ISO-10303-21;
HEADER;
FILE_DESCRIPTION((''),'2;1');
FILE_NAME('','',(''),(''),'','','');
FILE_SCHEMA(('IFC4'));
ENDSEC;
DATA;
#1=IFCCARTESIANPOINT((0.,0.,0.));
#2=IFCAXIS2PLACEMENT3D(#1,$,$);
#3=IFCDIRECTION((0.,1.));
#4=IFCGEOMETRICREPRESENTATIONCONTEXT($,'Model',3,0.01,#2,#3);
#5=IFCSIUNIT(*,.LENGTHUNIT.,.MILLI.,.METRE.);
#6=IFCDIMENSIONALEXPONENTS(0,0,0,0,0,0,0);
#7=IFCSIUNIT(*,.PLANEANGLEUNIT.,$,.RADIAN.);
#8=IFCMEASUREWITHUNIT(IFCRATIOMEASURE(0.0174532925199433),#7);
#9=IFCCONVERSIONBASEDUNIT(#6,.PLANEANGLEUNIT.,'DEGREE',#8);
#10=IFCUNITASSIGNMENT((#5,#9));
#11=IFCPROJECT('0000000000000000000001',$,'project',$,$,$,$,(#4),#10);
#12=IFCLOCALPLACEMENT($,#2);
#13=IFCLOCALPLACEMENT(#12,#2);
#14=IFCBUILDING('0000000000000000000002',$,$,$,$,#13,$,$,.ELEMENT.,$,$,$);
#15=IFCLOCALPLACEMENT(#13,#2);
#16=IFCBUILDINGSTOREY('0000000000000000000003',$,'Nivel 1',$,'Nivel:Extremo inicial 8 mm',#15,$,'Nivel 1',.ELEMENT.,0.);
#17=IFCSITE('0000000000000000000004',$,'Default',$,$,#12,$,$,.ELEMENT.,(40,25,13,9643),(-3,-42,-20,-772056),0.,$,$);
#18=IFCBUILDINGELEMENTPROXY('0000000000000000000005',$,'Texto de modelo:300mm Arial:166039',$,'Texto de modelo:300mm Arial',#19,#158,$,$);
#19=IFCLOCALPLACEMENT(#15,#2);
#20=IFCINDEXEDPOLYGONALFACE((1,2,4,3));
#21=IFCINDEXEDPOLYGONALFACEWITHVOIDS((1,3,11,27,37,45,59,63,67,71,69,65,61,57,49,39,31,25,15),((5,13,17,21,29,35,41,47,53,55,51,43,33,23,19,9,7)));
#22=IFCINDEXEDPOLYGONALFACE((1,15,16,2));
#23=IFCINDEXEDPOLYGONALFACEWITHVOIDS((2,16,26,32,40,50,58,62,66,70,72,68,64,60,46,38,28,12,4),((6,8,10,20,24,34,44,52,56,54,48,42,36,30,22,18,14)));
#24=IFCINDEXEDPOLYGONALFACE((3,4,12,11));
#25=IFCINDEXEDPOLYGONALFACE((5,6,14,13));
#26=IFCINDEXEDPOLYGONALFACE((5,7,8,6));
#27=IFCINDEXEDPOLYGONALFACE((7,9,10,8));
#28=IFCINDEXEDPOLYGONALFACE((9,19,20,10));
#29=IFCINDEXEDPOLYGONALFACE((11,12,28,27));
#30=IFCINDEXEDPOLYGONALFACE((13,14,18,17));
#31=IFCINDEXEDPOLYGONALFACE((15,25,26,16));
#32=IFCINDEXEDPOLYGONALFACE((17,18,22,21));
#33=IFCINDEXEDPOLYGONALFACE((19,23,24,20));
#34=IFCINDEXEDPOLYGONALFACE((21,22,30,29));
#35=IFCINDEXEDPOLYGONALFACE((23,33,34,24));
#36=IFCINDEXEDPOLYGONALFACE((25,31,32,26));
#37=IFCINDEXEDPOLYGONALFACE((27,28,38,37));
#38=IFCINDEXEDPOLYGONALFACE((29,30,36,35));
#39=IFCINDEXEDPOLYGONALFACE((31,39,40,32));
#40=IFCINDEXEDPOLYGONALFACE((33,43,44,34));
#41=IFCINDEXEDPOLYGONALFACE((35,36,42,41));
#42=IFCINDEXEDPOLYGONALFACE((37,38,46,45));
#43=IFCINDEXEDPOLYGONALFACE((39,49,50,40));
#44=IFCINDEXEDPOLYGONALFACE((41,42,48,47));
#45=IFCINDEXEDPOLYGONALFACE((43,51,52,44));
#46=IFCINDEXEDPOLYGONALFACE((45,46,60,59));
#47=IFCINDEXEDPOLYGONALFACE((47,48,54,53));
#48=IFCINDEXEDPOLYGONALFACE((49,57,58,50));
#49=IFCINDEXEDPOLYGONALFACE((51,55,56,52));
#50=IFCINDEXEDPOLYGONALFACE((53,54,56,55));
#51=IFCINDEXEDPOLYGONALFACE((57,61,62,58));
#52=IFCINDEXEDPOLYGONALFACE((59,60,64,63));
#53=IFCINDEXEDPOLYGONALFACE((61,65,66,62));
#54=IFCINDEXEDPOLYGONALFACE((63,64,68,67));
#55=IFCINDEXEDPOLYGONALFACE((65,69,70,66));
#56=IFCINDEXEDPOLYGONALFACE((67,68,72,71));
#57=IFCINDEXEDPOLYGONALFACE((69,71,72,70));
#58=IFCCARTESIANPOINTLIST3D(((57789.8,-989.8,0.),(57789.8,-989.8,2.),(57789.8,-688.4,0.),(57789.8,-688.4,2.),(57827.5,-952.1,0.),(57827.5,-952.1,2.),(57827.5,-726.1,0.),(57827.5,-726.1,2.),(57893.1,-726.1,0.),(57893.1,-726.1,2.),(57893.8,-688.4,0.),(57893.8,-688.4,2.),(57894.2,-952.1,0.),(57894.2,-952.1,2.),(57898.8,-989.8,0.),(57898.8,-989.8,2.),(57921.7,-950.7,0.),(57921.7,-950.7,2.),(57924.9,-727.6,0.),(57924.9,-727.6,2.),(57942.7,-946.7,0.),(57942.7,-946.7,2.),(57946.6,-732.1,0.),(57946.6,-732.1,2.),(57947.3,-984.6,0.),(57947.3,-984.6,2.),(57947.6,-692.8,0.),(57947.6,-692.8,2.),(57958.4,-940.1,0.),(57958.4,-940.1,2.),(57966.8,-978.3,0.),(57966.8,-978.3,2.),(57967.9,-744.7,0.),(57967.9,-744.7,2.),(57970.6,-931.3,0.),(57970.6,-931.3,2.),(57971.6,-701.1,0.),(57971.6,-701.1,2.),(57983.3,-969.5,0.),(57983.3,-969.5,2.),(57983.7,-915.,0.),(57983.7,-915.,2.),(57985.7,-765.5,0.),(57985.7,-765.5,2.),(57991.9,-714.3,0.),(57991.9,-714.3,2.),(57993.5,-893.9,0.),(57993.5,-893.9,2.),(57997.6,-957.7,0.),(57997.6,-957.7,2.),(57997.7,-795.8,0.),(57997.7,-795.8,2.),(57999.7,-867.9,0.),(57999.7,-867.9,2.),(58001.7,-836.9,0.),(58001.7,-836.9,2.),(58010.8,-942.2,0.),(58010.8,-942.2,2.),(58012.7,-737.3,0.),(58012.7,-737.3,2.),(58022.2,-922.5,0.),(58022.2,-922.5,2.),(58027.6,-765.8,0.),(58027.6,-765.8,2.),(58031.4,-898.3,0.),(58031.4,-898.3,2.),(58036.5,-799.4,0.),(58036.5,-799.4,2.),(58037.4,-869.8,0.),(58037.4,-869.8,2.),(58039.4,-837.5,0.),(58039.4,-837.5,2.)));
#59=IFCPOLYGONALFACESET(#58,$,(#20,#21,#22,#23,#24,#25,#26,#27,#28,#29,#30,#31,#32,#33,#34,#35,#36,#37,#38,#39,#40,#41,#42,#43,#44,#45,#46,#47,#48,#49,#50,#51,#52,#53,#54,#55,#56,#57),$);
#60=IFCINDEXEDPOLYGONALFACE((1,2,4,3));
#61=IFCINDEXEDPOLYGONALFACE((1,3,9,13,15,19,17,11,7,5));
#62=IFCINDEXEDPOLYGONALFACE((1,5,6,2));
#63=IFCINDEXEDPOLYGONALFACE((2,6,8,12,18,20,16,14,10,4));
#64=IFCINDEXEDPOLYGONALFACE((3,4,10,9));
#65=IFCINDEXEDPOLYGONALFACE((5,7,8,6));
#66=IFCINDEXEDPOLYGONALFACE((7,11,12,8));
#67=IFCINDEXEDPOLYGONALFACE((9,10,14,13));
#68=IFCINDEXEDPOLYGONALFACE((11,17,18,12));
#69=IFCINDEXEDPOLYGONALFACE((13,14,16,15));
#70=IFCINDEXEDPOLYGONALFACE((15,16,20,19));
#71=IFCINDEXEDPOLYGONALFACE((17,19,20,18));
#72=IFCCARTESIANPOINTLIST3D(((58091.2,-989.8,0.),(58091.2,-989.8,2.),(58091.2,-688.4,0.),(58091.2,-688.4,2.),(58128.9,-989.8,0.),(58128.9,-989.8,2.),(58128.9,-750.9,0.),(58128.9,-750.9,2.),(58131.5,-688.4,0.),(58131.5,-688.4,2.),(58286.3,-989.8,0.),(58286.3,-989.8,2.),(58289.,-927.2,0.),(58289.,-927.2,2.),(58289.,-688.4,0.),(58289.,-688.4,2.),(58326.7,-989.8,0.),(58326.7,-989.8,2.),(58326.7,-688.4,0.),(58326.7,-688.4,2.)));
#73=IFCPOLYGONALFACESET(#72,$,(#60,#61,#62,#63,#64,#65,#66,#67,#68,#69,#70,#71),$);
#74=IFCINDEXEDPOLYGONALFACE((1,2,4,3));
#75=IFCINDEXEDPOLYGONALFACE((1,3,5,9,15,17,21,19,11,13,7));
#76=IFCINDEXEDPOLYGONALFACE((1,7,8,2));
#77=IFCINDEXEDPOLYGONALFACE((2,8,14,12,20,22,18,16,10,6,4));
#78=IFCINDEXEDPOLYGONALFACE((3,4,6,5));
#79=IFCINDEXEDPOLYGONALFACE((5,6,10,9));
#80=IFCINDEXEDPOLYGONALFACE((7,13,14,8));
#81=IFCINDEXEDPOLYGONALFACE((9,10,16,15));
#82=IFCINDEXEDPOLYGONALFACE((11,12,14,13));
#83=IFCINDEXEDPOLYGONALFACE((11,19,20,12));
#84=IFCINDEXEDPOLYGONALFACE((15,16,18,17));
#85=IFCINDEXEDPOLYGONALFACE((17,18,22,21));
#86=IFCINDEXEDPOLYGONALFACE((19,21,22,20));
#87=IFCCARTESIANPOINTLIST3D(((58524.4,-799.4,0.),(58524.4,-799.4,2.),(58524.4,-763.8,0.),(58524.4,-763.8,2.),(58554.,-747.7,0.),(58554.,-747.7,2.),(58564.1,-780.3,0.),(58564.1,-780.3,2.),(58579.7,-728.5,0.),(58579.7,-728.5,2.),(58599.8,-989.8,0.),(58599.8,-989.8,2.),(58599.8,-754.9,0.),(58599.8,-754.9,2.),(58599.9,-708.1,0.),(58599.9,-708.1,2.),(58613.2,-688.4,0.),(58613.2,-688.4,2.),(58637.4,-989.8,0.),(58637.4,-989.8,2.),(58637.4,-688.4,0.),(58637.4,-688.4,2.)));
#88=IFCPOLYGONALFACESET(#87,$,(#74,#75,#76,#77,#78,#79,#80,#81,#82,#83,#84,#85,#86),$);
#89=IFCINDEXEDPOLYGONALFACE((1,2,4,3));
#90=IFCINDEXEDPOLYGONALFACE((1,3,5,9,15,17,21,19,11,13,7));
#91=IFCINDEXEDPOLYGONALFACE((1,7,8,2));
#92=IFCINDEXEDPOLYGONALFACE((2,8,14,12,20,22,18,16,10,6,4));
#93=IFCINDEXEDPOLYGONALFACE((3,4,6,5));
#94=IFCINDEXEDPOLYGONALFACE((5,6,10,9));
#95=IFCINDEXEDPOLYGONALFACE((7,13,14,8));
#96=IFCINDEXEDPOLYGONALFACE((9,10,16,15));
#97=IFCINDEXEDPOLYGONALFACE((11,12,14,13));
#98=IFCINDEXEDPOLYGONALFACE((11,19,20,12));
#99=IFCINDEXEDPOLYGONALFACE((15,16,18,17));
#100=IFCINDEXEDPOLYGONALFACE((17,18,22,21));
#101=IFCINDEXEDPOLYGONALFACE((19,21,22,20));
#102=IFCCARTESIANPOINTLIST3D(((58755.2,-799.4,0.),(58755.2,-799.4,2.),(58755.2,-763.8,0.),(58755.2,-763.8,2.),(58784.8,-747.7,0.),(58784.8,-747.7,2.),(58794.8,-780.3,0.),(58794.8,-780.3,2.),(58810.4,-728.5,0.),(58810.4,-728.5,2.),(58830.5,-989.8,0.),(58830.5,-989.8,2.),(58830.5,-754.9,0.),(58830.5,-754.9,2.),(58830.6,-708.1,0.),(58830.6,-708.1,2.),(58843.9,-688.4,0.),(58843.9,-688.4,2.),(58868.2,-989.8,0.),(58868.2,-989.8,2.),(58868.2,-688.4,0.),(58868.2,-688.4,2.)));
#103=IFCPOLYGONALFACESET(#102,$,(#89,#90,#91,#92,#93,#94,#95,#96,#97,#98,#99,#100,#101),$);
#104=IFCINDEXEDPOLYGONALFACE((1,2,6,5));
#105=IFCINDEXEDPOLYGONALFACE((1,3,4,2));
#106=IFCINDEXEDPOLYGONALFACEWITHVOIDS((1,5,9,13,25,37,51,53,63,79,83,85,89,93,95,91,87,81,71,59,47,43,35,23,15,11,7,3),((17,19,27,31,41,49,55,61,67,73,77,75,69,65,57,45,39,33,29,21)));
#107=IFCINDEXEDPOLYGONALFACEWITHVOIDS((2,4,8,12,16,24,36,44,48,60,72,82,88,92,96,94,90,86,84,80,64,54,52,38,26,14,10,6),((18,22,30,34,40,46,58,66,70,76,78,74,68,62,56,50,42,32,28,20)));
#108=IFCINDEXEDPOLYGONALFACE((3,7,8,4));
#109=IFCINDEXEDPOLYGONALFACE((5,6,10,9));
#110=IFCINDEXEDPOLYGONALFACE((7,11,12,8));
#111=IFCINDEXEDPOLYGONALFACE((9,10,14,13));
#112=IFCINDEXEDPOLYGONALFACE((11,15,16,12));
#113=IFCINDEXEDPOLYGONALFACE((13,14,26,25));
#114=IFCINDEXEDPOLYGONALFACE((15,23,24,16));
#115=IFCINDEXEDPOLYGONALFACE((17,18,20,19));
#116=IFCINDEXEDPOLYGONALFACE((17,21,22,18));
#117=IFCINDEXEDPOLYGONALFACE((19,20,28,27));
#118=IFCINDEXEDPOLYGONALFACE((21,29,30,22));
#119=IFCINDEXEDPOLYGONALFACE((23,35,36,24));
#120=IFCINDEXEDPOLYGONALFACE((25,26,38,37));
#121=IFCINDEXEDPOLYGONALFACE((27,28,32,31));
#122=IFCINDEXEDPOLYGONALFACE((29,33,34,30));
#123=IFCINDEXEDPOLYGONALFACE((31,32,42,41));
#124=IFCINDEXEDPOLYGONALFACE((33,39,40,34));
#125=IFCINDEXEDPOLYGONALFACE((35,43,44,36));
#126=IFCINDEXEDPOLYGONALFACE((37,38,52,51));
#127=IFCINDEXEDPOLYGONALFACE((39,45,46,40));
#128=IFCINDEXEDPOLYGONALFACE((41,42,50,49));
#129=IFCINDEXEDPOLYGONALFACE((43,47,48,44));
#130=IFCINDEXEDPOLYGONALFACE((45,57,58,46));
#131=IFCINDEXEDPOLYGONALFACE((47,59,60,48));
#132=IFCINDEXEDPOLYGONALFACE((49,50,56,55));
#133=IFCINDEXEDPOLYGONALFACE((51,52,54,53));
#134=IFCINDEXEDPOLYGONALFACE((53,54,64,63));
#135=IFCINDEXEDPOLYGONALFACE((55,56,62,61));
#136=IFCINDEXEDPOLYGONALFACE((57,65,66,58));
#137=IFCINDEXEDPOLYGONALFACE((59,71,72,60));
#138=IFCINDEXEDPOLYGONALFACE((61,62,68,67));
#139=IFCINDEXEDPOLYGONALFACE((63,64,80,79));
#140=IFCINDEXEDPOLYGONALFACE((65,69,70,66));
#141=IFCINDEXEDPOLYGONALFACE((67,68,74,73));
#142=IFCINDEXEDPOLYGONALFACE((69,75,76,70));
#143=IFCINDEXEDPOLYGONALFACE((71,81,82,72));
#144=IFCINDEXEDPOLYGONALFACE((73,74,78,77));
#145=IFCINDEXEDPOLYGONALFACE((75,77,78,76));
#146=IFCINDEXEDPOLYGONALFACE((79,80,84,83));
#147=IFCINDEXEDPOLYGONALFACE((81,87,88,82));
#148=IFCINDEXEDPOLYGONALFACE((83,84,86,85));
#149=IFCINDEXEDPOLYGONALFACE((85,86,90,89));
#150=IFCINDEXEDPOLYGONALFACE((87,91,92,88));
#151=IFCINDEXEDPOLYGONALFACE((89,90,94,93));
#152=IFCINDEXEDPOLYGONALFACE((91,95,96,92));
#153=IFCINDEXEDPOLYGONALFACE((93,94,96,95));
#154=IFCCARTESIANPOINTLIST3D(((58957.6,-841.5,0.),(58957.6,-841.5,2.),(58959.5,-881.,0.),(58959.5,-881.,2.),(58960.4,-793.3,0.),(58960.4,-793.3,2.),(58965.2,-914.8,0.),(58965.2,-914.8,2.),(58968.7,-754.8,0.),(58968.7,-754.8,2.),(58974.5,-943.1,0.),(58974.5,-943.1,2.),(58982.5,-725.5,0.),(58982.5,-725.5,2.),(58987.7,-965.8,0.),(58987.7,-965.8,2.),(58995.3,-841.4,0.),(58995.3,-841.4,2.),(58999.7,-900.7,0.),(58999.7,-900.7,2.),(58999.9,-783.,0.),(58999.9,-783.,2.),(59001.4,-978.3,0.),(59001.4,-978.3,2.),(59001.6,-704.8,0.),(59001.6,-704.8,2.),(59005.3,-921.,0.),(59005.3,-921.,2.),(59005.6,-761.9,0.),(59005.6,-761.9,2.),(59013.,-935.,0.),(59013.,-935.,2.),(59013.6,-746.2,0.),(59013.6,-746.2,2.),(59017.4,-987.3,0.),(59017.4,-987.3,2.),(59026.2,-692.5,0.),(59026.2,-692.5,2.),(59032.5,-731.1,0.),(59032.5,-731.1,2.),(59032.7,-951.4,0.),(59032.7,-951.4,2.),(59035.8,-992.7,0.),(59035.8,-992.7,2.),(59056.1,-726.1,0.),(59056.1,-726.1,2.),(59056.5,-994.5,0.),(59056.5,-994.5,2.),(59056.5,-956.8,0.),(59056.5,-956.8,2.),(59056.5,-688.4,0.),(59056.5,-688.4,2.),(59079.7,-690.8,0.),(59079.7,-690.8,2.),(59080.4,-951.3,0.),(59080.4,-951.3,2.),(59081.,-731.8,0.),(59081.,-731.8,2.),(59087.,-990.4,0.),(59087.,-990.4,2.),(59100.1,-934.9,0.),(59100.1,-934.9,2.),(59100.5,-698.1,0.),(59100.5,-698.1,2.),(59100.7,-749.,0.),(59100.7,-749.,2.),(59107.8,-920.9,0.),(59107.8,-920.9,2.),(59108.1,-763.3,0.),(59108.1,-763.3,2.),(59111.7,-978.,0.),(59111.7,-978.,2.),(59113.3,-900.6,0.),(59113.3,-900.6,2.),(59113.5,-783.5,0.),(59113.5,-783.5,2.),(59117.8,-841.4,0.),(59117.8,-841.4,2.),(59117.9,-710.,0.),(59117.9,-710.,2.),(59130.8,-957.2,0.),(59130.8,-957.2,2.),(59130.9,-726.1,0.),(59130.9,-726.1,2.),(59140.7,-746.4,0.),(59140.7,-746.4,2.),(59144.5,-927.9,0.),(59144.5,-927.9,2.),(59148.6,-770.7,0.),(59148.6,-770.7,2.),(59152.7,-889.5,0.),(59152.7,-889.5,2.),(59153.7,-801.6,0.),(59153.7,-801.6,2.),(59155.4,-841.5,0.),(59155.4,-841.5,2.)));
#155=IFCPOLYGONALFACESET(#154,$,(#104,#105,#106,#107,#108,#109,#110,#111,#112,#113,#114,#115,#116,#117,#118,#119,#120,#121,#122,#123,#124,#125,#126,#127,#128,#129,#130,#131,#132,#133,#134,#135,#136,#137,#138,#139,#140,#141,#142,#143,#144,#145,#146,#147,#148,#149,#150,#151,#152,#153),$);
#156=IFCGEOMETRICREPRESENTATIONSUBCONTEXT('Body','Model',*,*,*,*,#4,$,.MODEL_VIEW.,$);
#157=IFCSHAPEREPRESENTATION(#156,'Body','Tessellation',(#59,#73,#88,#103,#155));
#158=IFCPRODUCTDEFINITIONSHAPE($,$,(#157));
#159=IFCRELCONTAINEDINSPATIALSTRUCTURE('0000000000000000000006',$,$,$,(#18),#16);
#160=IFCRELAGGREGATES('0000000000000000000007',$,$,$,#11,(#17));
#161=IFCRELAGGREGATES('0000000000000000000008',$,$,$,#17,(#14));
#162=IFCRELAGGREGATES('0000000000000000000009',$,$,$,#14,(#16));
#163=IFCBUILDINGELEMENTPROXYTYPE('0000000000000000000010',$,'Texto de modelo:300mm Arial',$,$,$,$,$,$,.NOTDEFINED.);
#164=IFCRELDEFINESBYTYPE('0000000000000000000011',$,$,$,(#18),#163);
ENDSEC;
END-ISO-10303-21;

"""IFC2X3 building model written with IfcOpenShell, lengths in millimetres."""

from ifc_helpers import new_model, entity, si_unit, converted_unit, direction, frame, origin, place, context, subcontext, project, spatial, polyline, outline, extrude, type_object, element, save


model = new_model("IFC2X3")

# Units and contexts
model_context = context("Model", 3, precision=0.01, world=origin(), true_north=direction((0.0, 1.0)))
body_context = subcontext(model_context, "Body", "Model", "MODEL_VIEW")
ifc_project = project(units=[si_unit("LENGTHUNIT", "METRE", prefix="MILLI"), converted_unit("PLANEANGLEUNIT", "DEGREE", entity("IfcRatioMeasure", 0.0174532925199433), si_unit("PLANEANGLEUNIT", "RADIAN"), dimensions=[0, 0, 0, 0, 0, 0, 0])], contexts=[model_context])

# Site, building, storey
site_placement = place(None, origin())
site = spatial("IfcSite", under=ifc_project, at=site_placement, Name="Default", CompositionType="ELEMENT", RefLatitude=(40, 25, 13, 9643), RefLongitude=(-3, -42, -20, -772056), RefElevation=0.0)
building_placement = place(site_placement, origin())
building = spatial("IfcBuilding", under=site, at=building_placement, CompositionType="ELEMENT")
storey_placement = place(building_placement, origin())
storey = spatial("IfcBuildingStorey", under=building, at=storey_placement, Name="Nivel 1", ObjectType="Nivel:Extremo inicial 8 mm", LongName="Nivel 1", CompositionType="ELEMENT", Elevation=0.0)

# Building element proxy
building_element_proxy_type_1 = type_object("IfcBuildingElementProxyType", Name="Texto de modelo:300mm Arial", PredefinedType="NOTDEFINED")
proxy_1_placement = place(storey_placement, frame((57789.8, -994.5, 0.0)))
element("IfcBuildingElementProxy", 1, at=proxy_1_placement, inside=storey, type_object=building_element_proxy_type_1, Name="Texto de modelo:300mm Arial:166039", ObjectType="Texto de modelo:300mm Arial", context=body_context, shape_type="SweptSolid", body=[
    extrude(outline(polyline([(-178.4, -141.0), (-69.4, -141.0), (-21.0, -135.8), (-1.4, -129.5), (15.0, -120.7), (29.4, -108.9), (42.6, -93.4), (54.0, -73.7), (63.2, -49.5), (69.2, -21.0), (71.2, 11.3), (68.2, 49.4), (59.3, 83.0), (44.5, 111.5), (23.7, 134.5), (3.4, 147.7), (-20.6, 156.1), (-74.4, 160.4), (-178.4, 160.4), (-178.4, -141.0)]), holes=[polyline([(-140.7, -103.3), (-140.7, 122.7), (-75.1, 122.7), (-43.3, 121.2), (-21.7, 116.7), (-0.4, 104.1), (17.4, 83.3), (29.5, 53.0), (33.5, 11.9), (31.5, -19.1), (25.3, -45.1), (15.5, -66.2), (2.4, -82.5), (-9.8, -91.3), (-25.6, -97.9), (-46.5, -101.9), (-74.1, -103.3), (-140.7, -103.3)])]), frame((178.4, 145.7, 0.0)), (0.0, 0.0, 1.0), 2.0),
    extrude(outline(polyline([(-117.7, -150.7), (-80.1, -150.7), (-80.1, 88.1), (77.4, -150.7), (117.7, -150.7), (117.7, 150.7), (80.1, 150.7), (80.1, -88.1), (-77.4, 150.7), (-117.7, 150.7), (-117.7, -150.7)])), frame((419.1, 155.4, 0.0)), (0.0, 0.0, 1.0), 2.0),
    extrude(outline(polyline([(-204.4, -52.5), (97.0, -52.5), (97.0, -28.2), (77.2, -14.9), (56.9, 5.3), (37.7, 30.9), (21.6, 60.5), (-14.0, 60.5), (5.0, 20.8), (30.4, -14.9), (-204.4, -14.9), (-204.4, -52.5)])), frame((795.1, 209.1, 0.0), z_axis=(0.0, 0.0, 1.0), x_axis=(0.0, 1.0, 0.0)), (0.0, 0.0, 1.0), 2.0),
    extrude(outline(polyline([(-204.4, -52.5), (97.0, -52.5), (97.0, -28.2), (77.2, -14.9), (56.9, 5.3), (37.7, 30.9), (21.6, 60.5), (-14.0, 60.5), (5.0, 20.8), (30.4, -14.9), (-204.4, -14.9), (-204.4, -52.5)])), frame((1025.8, 209.1, 0.0), z_axis=(0.0, 0.0, 1.0), x_axis=(0.0, 1.0, 0.0)), (0.0, 0.0, 1.0), 2.0),
    extrude(outline(polyline([(-5.6, -99.5), (33.9, -99.5), (68.0, -95.5), (96.7, -87.5), (120.0, -75.5), (133.2, -62.4), (142.9, -46.8), (149.1, -28.7), (151.9, -8.0), (149.2, 22.6), (138.0, 47.8), (118.2, 67.9), (89.5, 82.9), (51.6, 93.0), (3.8, 98.0), (-36.2, 98.2), (-67.3, 94.5), (-91.9, 87.9), (-112.6, 79.0), (-129.4, 66.8), (-142.0, 50.0), (-150.3, 29.6), (-153.8, 6.5), (-151.2, -23.9), (-140.1, -49.1), (-120.3, -69.2), (-91.7, -84.4), (-53.6, -94.5), (-5.6, -99.5)]), holes=[polyline([(-3.9, -61.9), (-62.1, -54.6), (-82.9, -47.9), (-98.1, -39.2), (-112.3, -19.5), (-116.2, 4.3), (-109.3, 28.9), (-91.2, 47.7), (-76.5, 54.5), (-56.1, 58.9), (1.9, 60.4), (60.8, 53.2), (80.8, 46.7), (94.5, 38.3), (109.9, 17.8), (114.3, -6.3), (107.7, -29.8), (90.4, -48.7), (76.0, -55.8), (55.5, -60.3), (-3.9, -61.9)])]), frame((1267.5, 152.1, 0.0), z_axis=(0.0, 0.0, 1.0), x_axis=(0.047515, -0.998871, 0.0)), (0.0, 0.0, 1.0), 2.0),
])

save(model, "model.ifc")
